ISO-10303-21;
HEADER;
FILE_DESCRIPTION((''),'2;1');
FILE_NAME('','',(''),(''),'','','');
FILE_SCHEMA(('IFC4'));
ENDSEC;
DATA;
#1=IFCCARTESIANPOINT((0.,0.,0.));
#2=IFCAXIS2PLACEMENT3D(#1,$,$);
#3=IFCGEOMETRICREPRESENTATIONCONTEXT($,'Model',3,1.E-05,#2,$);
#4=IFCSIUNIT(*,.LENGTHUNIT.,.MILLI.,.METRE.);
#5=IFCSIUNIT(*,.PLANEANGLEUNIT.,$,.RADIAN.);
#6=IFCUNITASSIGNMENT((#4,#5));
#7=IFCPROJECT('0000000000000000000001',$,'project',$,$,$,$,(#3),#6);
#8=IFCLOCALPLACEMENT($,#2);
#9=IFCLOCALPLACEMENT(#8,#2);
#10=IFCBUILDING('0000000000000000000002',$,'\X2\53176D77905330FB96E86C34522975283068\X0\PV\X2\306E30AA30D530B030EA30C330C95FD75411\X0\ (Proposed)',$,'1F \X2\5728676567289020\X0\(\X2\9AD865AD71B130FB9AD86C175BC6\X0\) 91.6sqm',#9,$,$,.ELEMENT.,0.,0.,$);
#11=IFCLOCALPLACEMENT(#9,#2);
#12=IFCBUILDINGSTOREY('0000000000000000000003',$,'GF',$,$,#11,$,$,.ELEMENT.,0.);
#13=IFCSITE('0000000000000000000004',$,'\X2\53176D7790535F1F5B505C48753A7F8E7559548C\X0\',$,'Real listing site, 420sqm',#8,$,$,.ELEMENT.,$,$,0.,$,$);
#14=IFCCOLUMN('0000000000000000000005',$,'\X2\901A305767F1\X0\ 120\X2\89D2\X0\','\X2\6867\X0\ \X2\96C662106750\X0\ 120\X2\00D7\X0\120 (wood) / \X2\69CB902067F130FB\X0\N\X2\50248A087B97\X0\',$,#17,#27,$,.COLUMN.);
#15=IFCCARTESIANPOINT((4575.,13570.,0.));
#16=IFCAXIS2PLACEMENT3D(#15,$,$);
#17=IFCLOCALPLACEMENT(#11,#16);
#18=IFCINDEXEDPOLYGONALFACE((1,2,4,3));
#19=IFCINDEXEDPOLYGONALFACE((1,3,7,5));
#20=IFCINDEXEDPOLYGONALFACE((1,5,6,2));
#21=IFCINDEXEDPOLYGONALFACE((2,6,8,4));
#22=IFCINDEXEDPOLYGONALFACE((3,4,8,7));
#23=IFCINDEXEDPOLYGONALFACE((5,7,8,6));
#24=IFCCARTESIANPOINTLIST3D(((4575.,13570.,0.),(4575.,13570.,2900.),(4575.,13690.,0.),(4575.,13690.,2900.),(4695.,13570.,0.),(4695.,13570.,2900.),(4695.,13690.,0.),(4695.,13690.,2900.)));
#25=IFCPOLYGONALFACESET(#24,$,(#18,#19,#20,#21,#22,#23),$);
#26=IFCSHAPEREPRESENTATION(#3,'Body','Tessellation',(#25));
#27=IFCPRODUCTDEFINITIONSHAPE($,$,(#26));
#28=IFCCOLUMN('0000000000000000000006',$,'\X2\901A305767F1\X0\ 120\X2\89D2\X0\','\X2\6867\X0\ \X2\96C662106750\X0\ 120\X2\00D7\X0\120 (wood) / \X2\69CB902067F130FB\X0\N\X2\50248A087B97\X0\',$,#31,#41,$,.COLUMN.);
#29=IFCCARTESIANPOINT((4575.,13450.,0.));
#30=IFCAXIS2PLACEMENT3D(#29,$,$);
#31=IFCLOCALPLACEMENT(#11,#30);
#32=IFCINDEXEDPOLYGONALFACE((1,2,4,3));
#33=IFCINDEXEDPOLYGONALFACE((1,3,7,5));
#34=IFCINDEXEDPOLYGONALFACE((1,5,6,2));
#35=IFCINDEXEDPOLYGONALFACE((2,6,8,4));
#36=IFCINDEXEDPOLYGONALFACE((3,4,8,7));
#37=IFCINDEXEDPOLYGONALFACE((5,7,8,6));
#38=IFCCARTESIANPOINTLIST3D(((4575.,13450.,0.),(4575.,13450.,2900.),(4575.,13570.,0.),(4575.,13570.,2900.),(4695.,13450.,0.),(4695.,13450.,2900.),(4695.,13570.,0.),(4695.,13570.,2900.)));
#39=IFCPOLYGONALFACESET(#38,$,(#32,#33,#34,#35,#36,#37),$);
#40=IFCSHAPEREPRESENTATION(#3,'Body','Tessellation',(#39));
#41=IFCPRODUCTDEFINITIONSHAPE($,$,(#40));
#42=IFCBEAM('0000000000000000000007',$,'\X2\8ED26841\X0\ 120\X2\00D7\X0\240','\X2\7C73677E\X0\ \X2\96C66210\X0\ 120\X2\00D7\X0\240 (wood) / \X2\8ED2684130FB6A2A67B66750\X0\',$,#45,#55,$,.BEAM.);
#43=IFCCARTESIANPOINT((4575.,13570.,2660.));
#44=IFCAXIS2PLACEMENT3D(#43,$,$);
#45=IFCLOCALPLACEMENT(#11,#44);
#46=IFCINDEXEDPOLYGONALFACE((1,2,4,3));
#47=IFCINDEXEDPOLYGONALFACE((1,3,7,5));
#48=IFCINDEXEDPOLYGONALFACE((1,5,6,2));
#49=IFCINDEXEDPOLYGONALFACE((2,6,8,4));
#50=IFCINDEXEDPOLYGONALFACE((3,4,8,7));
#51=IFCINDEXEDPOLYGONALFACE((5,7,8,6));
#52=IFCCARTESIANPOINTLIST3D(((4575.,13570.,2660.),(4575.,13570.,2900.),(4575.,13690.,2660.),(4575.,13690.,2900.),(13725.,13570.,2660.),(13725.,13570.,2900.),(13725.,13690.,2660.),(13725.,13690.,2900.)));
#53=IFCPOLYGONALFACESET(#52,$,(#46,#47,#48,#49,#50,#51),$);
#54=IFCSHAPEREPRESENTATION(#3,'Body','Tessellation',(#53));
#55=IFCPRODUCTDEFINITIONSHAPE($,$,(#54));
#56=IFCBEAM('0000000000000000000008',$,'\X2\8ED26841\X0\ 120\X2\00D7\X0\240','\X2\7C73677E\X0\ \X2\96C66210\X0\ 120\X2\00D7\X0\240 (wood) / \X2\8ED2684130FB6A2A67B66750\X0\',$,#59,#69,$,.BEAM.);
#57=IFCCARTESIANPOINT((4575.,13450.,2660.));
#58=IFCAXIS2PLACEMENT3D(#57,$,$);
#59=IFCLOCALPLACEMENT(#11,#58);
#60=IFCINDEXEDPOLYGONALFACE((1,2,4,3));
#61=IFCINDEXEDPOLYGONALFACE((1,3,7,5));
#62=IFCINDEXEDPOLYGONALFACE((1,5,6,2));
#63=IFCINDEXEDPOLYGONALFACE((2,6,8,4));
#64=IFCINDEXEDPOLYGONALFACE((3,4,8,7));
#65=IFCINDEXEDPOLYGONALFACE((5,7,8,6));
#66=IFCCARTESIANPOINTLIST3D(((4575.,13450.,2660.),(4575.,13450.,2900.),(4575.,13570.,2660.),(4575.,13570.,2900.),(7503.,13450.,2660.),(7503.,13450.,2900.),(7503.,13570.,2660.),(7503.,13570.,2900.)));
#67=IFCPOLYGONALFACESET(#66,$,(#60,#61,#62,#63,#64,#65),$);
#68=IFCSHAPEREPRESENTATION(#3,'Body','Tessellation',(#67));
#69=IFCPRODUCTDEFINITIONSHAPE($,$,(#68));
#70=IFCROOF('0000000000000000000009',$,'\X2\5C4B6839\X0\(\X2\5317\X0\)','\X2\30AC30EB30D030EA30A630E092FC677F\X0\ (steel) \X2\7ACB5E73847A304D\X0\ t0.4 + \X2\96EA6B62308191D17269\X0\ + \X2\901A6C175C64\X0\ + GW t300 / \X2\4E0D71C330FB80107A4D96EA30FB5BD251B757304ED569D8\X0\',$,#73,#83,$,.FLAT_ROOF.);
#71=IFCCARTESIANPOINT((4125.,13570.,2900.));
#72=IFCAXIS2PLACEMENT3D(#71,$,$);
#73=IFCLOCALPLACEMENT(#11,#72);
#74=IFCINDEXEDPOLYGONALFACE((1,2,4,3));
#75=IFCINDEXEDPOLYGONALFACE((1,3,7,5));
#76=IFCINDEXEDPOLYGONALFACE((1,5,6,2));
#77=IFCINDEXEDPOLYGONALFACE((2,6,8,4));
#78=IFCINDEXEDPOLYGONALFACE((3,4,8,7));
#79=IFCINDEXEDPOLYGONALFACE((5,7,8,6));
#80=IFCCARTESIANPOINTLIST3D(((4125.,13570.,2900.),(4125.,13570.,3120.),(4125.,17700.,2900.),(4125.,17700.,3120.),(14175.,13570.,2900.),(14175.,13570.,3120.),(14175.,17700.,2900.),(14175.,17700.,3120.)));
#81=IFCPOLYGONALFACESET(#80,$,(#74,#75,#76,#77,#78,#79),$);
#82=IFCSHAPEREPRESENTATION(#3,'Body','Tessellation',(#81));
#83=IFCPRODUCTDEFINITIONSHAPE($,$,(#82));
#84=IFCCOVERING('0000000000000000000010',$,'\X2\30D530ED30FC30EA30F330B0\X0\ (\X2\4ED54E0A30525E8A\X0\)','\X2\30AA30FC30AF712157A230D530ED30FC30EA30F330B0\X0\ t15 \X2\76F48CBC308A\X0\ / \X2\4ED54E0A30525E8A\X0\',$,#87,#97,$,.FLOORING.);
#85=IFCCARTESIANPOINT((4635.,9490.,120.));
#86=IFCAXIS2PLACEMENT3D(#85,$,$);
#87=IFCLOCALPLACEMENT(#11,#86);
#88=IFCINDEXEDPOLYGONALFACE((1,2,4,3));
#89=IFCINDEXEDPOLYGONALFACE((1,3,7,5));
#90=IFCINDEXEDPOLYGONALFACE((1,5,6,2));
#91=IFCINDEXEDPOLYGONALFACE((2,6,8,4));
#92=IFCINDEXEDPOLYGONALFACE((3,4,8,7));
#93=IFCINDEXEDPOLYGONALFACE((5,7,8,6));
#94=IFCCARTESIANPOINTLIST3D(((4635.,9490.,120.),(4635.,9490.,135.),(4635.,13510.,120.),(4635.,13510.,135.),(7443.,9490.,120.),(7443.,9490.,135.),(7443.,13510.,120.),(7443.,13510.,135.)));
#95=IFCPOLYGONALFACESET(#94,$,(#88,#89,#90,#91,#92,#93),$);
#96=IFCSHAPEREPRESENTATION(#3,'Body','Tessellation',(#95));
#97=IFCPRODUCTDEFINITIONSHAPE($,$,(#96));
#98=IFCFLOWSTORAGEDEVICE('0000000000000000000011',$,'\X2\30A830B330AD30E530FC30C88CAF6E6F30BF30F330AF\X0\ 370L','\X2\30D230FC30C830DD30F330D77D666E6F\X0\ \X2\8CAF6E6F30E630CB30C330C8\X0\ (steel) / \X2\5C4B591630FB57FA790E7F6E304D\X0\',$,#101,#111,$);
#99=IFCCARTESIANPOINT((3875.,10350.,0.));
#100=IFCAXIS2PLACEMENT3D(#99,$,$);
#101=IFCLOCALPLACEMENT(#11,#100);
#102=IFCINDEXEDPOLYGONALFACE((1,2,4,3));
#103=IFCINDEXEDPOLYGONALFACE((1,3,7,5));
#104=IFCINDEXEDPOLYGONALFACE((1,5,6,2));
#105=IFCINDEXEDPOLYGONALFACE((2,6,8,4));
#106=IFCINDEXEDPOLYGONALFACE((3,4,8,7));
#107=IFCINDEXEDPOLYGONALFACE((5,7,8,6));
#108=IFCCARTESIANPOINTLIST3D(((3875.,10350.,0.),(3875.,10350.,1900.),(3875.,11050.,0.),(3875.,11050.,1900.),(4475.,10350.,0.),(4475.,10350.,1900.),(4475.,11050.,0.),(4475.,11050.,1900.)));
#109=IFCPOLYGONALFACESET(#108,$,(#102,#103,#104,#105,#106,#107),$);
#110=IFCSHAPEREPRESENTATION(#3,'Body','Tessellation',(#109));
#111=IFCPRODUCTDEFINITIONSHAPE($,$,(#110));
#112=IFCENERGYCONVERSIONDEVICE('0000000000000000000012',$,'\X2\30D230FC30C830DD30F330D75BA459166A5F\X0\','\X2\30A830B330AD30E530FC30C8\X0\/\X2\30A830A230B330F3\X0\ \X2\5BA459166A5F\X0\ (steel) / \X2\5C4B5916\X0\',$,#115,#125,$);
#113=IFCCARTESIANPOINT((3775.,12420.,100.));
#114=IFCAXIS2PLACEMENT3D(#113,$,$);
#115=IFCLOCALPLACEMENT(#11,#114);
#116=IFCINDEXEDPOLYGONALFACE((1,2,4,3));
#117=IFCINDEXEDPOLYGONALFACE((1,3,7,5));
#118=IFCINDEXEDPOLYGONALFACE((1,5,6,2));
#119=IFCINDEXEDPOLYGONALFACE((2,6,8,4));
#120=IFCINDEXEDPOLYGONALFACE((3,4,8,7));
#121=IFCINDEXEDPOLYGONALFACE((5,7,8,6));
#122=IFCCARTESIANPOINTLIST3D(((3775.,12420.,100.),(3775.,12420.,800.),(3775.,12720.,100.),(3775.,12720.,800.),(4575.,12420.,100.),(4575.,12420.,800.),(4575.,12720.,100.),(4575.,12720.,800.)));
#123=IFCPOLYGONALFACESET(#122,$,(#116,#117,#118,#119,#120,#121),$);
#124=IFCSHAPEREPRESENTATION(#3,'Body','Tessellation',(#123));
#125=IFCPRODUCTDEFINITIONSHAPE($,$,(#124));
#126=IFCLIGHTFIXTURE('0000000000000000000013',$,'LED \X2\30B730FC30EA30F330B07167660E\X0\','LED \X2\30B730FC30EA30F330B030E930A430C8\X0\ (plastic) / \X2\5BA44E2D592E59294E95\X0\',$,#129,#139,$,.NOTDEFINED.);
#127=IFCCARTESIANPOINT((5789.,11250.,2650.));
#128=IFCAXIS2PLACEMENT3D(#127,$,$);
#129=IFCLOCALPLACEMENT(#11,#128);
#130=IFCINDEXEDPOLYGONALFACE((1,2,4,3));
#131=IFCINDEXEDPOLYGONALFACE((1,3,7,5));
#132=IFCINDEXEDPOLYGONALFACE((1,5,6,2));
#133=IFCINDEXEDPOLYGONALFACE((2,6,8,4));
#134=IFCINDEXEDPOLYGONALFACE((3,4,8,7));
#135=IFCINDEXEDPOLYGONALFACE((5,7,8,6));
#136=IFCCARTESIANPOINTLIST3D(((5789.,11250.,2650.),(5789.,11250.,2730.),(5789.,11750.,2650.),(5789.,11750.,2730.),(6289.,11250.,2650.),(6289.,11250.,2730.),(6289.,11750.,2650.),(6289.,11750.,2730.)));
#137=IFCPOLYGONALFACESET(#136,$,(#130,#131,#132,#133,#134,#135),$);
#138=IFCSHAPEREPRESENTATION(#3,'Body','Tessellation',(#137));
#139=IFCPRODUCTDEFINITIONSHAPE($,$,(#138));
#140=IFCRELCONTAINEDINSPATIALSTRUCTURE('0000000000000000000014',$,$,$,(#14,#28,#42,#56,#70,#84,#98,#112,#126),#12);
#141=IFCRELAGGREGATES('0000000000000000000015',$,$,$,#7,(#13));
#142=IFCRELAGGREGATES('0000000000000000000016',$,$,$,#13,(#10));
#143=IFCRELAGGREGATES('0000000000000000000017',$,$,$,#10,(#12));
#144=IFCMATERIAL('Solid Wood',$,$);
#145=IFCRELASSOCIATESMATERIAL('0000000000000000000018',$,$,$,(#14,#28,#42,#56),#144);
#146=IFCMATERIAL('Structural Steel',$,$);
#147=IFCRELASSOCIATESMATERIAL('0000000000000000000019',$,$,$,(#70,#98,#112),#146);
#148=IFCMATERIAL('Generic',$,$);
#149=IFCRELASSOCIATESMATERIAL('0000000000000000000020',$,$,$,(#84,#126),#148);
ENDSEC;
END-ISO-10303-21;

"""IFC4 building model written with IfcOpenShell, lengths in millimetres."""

from ifc_helpers import new_model, si_unit, frame, frame_2d, origin, place, context, project, spatial, rectangle, extrude, material, element, save


model = new_model("IFC4")

# Units and contexts
model_context = context("Model", 3, precision=1e-05, world=origin())
ifc_project = project(units=[si_unit("LENGTHUNIT", "METRE", prefix="MILLI"), si_unit("PLANEANGLEUNIT", "RADIAN")], contexts=[model_context])

# Site, building, storey
site_placement = place(None, origin())
site = spatial("IfcSite", under=ifc_project, at=site_placement, Name="北海道弟子屈町美留和", ObjectType="Real listing site, 420sqm", CompositionType="ELEMENT", RefElevation=0.0)
building_placement = place(site_placement, origin())
building = spatial("IfcBuilding", under=site, at=building_placement, Name="北海道・雨水利用とPVのオフグリッド志向 (Proposed)", ObjectType="1F 在来木造(高断熱・高気密) 91.6sqm", CompositionType="ELEMENT", ElevationOfRefHeight=0.0, ElevationOfTerrain=0.0)
storey_placement = place(building_placement, origin())
storey = spatial("IfcBuildingStorey", under=building, at=storey_placement, Name="GF", CompositionType="ELEMENT", Elevation=0.0)

# Columns
ifc_material_1 = material(Name="Solid Wood")
column_1_placement = place(storey_placement, frame((4575.0, 13570.0, 0.0)))
element("IfcColumn", 1, at=column_1_placement, inside=storey, material=ifc_material_1, Name="通し柱 120角", Description="桧 集成材 120×120 (wood) / 構造柱・N値計算", PredefinedType="COLUMN", context=model_context, shape_type="SweptSolid", body=[
    extrude(rectangle(XDim=120.0, YDim=120.0, at=frame_2d((60.0, 60.0))), frame((4575.0, 13570.0, 0.0)), (0.0, 0.0, 1.0), 2900.0),
])
column_2_placement = place(storey_placement, frame((4575.0, 13450.0, 0.0)))
element("IfcColumn", 2, at=column_2_placement, inside=storey, material=ifc_material_1, Name="通し柱 120角", Description="桧 集成材 120×120 (wood) / 構造柱・N値計算", PredefinedType="COLUMN", context=model_context, shape_type="SweptSolid", body=[
    extrude(rectangle(XDim=120.0, YDim=120.0, at=frame_2d((60.0, 60.0))), frame((4575.0, 13450.0, 0.0)), (0.0, 0.0, 1.0), 2900.0),
])

# Beams
beam_1_placement = place(storey_placement, frame((4575.0, 13570.0, 2660.0)))
element("IfcBeam", 3, at=beam_1_placement, inside=storey, material=ifc_material_1, Name="軒桁 120×240", Description="米松 集成 120×240 (wood) / 軒桁・横架材", PredefinedType="BEAM", context=model_context, shape_type="SweptSolid", body=[
    extrude(rectangle(XDim=9150.0, YDim=120.0, at=frame_2d((4575.0, 60.0))), frame((4575.0, 13570.0, 2660.0)), (0.0, 0.0, 1.0), 240.0),
])
beam_2_placement = place(storey_placement, frame((4575.0, 13450.0, 2660.0)))
element("IfcBeam", 4, at=beam_2_placement, inside=storey, material=ifc_material_1, Name="軒桁 120×240", Description="米松 集成 120×240 (wood) / 軒桁・横架材", PredefinedType="BEAM", context=model_context, shape_type="SweptSolid", body=[
    extrude(rectangle(XDim=2928.0, YDim=120.0, at=frame_2d((1464.0, 60.0))), frame((4575.0, 13450.0, 2660.0)), (0.0, 0.0, 1.0), 240.0),
])

# Roof
ifc_material_2 = material(Name="Structural Steel")
roof_placement = place(storey_placement, frame((4125.0, 13570.0, 2900.0)))
element("IfcRoof", 5, at=roof_placement, inside=storey, material=ifc_material_2, Name="屋根(北)", Description="ガルバリウム鋼板 (steel) 立平葺き t0.4 + 雪止め金物 + 通気層 + GW t300 / 不燃・耐積雪・寒冷地仕様", PredefinedType="FLAT_ROOF", context=model_context, shape_type="SweptSolid", body=[
    extrude(rectangle(XDim=10050.0, YDim=4130.0, at=frame_2d((5025.0, 2065.0))), frame((4125.0, 13570.0, 2900.0)), (0.0, 0.0, 1.0), 220.0),
])

# Covering
ifc_material_3 = material(Name="Generic")
covering_placement = place(storey_placement, frame((4635.0, 9490.0, 120.0)))
element("IfcCovering", 6, at=covering_placement, inside=storey, material=ifc_material_3, Name="フローリング (仕上げ床)", Description="オーク無垢フローリング t15 直貼り / 仕上げ床", PredefinedType="FLOORING", context=model_context, shape_type="SweptSolid", body=[
    extrude(rectangle(XDim=2808.0, YDim=4020.0, at=frame_2d((1404.0, 2010.0))), frame((4635.0, 9490.0, 120.0)), (0.0, 0.0, 1.0), 15.0),
])

# Flow storage device
flow_storage_device_placement = place(storey_placement, frame((3875.0, 10350.0, 0.0)))
element("IfcFlowStorageDevice", 7, at=flow_storage_device_placement, inside=storey, material=ifc_material_2, Name="エコキュート貯湯タンク 370L", Description="ヒートポンプ給湯 貯湯ユニット (steel) / 屋外・基礎置き", context=model_context, shape_type="SweptSolid", body=[
    extrude(rectangle(XDim=600.0, YDim=700.0, at=frame_2d((300.0, 350.0))), frame((3875.0, 10350.0, 0.0)), (0.0, 0.0, 1.0), 1900.0),
])

# Energy conversion device
energy_conversion_device_placement = place(storey_placement, frame((3775.0, 12420.0, 100.0)))
element("IfcEnergyConversionDevice", 8, at=energy_conversion_device_placement, inside=storey, material=ifc_material_2, Name="ヒートポンプ室外機", Description="エコキュート/エアコン 室外機 (steel) / 屋外", context=model_context, shape_type="SweptSolid", body=[
    extrude(rectangle(XDim=800.0, YDim=300.0, at=frame_2d((400.0, 150.0))), frame((3775.0, 12420.0, 100.0)), (0.0, 0.0, 1.0), 700.0),
])

# Light fixture
light_fixture_placement = place(storey_placement, frame((5789.0, 11250.0, 2650.0)))
element("IfcLightFixture", 9, at=light_fixture_placement, inside=storey, material=ifc_material_3, Name="LED シーリング照明", Description="LED シーリングライト (plastic) / 室中央天井", PredefinedType="NOTDEFINED", context=model_context, shape_type="SweptSolid", body=[
    extrude(rectangle(XDim=500.0, YDim=500.0, at=frame_2d((250.0, 250.0))), frame((5789.0, 11250.0, 2650.0)), (0.0, 0.0, 1.0), 80.0),
])

save(model, "model.ifc")
